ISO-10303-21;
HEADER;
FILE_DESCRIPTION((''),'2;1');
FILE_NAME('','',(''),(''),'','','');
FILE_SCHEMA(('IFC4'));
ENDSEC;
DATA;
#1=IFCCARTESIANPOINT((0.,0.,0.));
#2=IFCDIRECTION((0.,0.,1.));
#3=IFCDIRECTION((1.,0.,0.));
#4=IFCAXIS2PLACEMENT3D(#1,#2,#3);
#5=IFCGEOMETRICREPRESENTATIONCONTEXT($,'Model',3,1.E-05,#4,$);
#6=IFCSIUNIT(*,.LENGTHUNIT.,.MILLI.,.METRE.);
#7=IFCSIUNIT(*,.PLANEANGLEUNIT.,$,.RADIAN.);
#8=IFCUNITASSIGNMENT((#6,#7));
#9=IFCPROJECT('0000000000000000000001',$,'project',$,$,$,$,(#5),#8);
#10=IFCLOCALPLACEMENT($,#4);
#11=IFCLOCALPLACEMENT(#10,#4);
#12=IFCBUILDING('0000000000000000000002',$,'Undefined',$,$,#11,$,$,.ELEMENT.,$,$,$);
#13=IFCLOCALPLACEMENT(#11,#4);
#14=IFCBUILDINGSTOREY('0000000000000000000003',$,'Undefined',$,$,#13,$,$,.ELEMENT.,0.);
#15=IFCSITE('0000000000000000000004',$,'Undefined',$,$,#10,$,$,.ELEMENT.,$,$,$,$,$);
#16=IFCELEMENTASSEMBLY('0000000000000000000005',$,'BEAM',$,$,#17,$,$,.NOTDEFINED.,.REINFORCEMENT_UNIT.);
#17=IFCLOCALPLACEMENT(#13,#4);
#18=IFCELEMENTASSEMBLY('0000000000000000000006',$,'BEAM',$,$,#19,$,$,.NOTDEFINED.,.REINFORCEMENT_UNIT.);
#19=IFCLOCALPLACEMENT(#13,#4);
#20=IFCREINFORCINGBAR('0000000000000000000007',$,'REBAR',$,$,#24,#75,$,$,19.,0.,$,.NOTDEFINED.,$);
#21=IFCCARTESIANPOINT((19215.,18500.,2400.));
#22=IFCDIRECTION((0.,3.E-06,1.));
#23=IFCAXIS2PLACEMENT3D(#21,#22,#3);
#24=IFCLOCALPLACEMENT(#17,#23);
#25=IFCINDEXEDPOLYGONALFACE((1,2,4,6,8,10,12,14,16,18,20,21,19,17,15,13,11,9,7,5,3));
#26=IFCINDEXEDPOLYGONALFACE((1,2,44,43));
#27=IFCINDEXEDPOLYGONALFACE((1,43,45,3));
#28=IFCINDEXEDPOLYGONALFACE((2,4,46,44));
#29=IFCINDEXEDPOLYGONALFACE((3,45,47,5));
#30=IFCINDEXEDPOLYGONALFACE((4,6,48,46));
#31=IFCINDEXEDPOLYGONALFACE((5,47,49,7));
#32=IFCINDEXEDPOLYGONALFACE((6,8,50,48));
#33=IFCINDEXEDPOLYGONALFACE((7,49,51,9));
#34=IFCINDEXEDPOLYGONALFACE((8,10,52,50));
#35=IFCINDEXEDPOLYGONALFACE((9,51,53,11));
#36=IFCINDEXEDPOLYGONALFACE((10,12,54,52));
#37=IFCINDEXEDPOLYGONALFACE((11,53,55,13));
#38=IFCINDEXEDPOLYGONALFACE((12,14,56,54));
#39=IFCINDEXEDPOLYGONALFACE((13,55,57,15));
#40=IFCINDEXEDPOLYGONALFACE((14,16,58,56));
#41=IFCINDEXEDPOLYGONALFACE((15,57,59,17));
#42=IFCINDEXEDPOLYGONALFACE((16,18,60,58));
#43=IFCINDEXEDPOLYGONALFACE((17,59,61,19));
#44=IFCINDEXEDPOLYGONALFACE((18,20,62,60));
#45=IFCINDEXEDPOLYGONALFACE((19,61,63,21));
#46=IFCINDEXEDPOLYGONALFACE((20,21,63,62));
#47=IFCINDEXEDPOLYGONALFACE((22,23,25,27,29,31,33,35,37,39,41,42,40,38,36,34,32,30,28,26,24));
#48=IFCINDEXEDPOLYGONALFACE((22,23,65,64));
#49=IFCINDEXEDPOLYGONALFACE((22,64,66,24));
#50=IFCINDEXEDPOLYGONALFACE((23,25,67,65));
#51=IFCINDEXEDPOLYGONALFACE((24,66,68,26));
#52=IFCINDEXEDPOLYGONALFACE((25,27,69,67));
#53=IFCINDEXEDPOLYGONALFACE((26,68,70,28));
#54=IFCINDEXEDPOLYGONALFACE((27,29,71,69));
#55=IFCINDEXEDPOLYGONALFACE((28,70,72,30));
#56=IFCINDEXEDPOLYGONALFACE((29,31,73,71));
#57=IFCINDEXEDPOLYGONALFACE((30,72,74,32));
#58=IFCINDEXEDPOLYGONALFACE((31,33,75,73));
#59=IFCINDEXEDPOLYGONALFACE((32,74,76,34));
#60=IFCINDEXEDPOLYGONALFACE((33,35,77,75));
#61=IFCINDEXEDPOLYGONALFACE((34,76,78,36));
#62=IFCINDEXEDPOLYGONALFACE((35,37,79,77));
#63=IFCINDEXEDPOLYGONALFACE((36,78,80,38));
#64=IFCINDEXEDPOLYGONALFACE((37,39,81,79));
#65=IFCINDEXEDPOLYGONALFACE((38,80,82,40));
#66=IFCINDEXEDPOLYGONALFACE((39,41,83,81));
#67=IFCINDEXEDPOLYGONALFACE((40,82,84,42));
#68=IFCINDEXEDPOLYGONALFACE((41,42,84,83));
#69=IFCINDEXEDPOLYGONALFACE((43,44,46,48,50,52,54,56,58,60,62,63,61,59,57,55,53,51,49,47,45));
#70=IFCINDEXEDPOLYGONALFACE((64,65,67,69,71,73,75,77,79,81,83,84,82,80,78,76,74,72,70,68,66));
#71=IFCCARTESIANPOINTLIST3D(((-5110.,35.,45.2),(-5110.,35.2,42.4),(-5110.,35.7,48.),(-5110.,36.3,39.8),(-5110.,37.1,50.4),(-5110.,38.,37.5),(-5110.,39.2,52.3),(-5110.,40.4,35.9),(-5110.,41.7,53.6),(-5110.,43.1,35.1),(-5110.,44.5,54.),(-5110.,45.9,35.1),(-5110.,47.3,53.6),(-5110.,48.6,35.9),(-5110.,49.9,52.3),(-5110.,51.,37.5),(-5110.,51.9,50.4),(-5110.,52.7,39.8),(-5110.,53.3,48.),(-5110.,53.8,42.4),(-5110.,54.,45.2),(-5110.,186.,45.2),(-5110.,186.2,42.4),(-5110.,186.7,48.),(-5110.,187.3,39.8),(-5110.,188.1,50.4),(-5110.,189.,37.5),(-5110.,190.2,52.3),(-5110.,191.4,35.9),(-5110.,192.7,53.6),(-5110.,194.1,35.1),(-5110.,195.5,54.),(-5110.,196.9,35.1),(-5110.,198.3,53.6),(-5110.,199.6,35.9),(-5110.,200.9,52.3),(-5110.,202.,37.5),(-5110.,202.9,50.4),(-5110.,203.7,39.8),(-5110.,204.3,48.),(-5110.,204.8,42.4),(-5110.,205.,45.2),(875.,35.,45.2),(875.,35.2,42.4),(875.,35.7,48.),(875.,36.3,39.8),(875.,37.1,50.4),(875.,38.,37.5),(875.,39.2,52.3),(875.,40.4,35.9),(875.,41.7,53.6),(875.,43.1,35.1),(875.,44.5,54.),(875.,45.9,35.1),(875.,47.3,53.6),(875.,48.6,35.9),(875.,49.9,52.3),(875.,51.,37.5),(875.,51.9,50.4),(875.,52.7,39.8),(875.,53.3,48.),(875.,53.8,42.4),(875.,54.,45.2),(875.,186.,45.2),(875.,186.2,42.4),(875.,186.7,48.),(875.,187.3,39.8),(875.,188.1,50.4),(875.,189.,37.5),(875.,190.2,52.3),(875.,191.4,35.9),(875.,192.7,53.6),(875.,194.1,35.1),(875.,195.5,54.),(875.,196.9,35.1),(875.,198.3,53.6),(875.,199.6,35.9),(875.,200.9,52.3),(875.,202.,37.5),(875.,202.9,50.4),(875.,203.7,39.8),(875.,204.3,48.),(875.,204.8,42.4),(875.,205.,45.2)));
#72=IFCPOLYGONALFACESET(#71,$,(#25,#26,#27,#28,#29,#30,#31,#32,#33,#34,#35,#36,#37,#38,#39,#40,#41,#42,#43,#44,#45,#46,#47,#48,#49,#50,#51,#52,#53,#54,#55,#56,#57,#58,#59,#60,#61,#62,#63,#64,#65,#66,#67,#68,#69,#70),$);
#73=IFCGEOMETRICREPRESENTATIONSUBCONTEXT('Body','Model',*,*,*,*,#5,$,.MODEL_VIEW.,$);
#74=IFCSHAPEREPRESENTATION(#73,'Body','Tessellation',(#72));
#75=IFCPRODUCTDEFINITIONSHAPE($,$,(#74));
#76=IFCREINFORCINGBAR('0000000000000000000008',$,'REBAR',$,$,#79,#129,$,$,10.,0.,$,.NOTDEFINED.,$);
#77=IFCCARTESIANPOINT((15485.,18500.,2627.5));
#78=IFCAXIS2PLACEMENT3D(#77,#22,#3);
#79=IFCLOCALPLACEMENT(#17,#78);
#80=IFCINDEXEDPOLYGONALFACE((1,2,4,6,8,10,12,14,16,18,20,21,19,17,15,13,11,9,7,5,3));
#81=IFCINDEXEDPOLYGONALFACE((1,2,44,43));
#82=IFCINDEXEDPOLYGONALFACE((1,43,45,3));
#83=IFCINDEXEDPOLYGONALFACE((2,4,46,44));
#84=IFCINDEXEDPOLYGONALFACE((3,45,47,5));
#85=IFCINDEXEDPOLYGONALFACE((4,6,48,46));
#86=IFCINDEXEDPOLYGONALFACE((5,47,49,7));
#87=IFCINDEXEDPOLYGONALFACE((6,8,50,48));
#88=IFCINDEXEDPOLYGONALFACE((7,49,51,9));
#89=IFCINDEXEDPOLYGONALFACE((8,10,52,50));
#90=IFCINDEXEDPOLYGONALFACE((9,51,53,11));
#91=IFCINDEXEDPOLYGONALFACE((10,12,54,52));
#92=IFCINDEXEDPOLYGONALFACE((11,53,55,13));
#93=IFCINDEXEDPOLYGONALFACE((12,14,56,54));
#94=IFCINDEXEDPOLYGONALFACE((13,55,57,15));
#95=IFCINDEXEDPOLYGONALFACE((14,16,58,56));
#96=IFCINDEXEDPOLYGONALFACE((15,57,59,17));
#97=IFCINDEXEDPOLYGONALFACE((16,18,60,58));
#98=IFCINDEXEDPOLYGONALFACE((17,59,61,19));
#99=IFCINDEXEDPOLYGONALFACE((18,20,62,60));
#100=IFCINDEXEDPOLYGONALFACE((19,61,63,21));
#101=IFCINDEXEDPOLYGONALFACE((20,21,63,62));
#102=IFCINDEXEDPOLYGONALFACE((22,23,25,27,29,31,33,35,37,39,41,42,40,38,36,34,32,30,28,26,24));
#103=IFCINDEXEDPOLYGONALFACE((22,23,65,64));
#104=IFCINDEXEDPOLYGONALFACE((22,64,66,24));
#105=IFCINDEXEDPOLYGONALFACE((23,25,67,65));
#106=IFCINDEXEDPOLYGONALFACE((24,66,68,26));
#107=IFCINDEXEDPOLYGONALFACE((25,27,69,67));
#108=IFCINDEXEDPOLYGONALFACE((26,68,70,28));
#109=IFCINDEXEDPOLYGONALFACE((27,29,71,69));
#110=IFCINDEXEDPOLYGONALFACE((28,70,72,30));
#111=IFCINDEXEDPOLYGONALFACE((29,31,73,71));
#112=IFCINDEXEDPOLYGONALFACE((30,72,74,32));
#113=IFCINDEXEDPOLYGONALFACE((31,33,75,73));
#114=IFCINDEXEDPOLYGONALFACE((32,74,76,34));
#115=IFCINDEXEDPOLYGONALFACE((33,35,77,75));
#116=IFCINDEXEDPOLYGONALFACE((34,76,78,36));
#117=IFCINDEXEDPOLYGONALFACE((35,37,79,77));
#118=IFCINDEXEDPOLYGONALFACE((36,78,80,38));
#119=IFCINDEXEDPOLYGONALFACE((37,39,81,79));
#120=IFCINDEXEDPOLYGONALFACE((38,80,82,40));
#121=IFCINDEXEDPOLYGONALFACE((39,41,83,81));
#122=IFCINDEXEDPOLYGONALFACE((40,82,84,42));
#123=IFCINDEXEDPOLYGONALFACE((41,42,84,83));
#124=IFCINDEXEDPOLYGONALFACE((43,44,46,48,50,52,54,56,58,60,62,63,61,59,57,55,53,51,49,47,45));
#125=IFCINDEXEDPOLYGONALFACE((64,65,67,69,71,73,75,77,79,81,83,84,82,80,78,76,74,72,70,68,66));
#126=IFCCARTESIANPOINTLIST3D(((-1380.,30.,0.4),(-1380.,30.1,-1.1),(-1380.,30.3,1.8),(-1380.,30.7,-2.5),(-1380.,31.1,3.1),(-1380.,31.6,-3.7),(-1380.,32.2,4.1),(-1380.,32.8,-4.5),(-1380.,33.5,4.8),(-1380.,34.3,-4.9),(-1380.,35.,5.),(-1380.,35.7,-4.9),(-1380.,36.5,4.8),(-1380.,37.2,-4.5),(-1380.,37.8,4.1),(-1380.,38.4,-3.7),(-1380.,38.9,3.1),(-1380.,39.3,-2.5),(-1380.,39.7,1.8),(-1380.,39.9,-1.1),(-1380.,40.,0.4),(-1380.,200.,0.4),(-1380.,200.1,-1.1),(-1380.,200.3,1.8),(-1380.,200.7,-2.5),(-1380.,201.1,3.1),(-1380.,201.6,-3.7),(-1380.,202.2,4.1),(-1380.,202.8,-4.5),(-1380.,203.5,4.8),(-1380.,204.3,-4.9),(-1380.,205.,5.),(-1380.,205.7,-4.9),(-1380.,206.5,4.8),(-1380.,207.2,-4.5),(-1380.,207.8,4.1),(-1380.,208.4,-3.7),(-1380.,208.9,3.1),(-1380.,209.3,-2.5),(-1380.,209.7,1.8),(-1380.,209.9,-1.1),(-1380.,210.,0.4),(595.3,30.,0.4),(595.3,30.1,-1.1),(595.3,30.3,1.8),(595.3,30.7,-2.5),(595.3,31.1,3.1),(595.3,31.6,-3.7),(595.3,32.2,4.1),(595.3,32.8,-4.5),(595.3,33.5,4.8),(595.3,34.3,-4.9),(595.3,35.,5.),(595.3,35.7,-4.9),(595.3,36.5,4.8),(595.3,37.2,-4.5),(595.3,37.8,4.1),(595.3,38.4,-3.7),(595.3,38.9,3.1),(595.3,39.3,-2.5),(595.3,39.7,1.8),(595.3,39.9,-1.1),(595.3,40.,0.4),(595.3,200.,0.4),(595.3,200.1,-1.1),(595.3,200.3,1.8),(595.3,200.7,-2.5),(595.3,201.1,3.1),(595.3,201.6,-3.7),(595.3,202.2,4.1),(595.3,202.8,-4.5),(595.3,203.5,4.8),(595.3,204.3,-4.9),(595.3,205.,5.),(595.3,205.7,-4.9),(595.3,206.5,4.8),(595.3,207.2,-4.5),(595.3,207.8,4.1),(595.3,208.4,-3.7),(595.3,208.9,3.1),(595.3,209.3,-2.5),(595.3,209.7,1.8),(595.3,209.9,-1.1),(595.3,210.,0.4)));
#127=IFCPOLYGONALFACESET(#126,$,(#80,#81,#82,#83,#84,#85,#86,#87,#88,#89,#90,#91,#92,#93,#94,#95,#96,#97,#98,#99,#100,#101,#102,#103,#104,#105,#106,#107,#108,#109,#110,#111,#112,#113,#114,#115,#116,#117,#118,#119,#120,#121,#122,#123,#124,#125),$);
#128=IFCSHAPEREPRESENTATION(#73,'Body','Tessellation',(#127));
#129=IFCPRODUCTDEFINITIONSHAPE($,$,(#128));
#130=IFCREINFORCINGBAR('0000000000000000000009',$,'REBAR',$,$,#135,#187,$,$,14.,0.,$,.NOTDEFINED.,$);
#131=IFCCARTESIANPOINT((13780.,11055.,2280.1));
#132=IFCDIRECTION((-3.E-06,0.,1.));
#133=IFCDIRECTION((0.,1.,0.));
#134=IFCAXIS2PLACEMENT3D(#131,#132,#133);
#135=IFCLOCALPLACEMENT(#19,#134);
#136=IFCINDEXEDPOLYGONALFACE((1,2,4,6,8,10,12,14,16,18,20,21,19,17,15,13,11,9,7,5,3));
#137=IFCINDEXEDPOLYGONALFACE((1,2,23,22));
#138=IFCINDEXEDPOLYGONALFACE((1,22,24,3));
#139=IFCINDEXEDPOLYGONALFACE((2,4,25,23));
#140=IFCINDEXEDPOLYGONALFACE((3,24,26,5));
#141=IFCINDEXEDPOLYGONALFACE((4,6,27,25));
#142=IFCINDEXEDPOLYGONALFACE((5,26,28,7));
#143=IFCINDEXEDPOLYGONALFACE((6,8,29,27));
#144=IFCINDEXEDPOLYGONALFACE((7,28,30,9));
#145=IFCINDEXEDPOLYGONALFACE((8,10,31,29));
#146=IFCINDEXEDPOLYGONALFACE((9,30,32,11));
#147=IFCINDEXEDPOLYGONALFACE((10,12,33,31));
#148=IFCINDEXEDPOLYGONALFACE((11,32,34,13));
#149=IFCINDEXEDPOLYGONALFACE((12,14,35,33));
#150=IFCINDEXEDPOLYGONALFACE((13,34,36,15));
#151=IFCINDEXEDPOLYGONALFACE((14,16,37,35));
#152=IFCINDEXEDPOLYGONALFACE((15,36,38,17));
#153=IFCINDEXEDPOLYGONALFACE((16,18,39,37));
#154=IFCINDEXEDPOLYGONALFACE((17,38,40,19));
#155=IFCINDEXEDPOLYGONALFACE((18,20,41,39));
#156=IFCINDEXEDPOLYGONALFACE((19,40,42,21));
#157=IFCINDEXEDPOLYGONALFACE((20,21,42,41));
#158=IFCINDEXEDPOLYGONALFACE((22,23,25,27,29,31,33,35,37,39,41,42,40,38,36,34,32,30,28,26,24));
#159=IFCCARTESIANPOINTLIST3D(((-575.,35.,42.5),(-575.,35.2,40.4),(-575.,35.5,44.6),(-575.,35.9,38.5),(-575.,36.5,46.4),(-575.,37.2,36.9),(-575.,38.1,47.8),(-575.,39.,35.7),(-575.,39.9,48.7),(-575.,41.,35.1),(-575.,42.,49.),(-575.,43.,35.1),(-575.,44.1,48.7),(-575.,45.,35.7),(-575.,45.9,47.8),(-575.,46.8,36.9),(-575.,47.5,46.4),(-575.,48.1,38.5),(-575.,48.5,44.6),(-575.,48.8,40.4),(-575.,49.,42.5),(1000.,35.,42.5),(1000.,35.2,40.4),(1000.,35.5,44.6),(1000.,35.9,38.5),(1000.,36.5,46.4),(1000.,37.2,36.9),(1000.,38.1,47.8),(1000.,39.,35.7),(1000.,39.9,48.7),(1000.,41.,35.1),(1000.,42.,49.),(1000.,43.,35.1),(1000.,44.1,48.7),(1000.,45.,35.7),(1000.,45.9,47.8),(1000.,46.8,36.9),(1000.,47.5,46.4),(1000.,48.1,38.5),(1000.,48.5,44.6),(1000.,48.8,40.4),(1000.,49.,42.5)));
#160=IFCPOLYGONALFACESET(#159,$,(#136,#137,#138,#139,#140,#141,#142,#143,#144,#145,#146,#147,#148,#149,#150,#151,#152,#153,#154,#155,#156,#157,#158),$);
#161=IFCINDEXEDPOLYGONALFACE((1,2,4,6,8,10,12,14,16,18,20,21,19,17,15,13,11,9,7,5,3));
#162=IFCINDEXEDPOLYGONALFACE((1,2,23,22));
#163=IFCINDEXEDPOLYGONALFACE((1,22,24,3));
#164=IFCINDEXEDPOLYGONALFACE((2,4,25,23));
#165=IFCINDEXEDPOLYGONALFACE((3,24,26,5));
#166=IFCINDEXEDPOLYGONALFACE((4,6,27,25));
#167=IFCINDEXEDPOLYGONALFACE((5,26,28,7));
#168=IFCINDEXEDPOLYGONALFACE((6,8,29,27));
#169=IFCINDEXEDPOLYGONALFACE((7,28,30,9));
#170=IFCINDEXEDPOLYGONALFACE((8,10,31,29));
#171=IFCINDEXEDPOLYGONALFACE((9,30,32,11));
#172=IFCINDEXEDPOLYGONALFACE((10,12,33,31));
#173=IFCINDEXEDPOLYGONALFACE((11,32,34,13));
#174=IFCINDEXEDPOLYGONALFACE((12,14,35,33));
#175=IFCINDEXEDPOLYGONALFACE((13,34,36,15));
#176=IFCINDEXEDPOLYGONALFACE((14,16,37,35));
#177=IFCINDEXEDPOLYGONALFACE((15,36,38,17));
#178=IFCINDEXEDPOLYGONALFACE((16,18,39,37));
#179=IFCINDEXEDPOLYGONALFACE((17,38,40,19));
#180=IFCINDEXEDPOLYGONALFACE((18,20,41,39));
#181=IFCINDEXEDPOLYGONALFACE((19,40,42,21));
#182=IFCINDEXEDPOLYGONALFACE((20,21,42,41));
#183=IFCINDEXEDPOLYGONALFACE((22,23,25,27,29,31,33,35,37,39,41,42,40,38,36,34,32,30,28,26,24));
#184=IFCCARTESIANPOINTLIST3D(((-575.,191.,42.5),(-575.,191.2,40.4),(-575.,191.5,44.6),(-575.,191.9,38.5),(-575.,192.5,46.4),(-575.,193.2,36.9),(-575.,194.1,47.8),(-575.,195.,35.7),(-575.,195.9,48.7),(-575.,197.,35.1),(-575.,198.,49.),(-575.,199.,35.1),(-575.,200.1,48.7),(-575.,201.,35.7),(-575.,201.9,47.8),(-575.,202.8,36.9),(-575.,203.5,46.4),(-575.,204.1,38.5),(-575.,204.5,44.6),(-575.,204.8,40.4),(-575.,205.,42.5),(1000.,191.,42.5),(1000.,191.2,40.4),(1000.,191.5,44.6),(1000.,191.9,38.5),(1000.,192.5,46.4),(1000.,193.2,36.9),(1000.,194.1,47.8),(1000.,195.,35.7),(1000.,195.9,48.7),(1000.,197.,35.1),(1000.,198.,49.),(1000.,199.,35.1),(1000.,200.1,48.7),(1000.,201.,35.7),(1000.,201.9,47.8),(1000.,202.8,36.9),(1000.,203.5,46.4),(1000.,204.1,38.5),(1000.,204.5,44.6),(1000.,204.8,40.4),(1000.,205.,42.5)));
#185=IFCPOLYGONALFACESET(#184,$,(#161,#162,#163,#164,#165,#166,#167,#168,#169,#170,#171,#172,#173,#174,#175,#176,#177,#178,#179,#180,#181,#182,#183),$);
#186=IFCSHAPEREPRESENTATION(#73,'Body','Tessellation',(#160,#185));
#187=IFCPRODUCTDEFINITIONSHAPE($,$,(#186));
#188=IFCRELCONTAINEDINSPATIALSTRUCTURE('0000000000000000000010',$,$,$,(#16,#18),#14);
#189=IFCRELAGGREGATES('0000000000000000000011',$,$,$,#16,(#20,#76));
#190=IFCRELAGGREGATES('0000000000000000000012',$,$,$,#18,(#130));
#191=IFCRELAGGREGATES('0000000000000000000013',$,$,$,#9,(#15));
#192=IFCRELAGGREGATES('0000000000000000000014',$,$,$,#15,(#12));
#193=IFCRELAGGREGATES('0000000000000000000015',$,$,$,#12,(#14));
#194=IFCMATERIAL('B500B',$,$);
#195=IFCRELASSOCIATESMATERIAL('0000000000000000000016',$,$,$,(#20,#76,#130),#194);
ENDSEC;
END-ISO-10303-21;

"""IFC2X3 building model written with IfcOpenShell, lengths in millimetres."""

from ifc_helpers import new_model, entity, si_unit, frame, origin_with_axes, place, context, subcontext, project, spatial, source, transform, mapped, material, element, aggregate, save


model = new_model("IFC2X3")

# Units and contexts
model_context = context("Model", 3, precision=1e-05, world=origin_with_axes())
body_context = subcontext(model_context, "Body", "Model", "MODEL_VIEW")
ifc_project = project(units=[si_unit("LENGTHUNIT", "METRE", prefix="MILLI"), si_unit("PLANEANGLEUNIT", "RADIAN")], contexts=[model_context])

# Site, building, storey
site_placement = place(None, origin_with_axes())
site = spatial("IfcSite", under=ifc_project, at=site_placement, Name="Undefined", CompositionType="ELEMENT")
building_placement = place(site_placement, origin_with_axes())
building = spatial("IfcBuilding", under=site, at=building_placement, Name="Undefined", CompositionType="ELEMENT")
storey_placement = place(building_placement, origin_with_axes())
storey = spatial("IfcBuildingStorey", under=building, at=storey_placement, Name="Undefined", CompositionType="ELEMENT", Elevation=0.0)

# Element assembly
assembly_1_placement = place(storey_placement, origin_with_axes())
assembly_1 = element("IfcElementAssembly", 1, at=assembly_1_placement, inside=storey, Name="BEAM", AssemblyPlace="NOTDEFINED", PredefinedType="REINFORCEMENT_UNIT")

# Element assembly
assembly_2_placement = place(storey_placement, origin_with_axes())
assembly_2 = element("IfcElementAssembly", 2, at=assembly_2_placement, inside=storey, Name="BEAM", AssemblyPlace="NOTDEFINED", PredefinedType="REINFORCEMENT_UNIT")

# Reinforcing bars
ifc_material_1 = material(Name="B500B")
shared_shape_1 = source(origin_with_axes(), body_context, "Body", "AdvancedSweptSolid", [
    entity("IfcSweptDiskSolid", entity("IfcTrimmedCurve", entity("IfcLine", entity("IfcCartesianPoint", [0.0, 0.0, 0.0]), entity("IfcVector", entity("IfcDirection", [1.0, 0.0, 0.0]), 1.0)), [entity("IfcParameterValue", 0.0)], [entity("IfcParameterValue", 5984.999614)], True, "PARAMETER"), 9.5, None, 0.0, 5985.0),
])
shared_shape_2 = source(origin_with_axes(), body_context, "Body", "AdvancedSweptSolid", [
    entity("IfcSweptDiskSolid", entity("IfcTrimmedCurve", entity("IfcLine", entity("IfcCartesianPoint", [0.0, 0.0, 0.0]), entity("IfcVector", entity("IfcDirection", [1.0, 0.0, 0.0]), 1.0)), [entity("IfcParameterValue", 0.0)], [entity("IfcParameterValue", 5984.999614)], True, "PARAMETER"), 9.5, None, 0.0, 5985.0),
])
reinforcing_bar_1_placement = place(assembly_1_placement, frame((19215.0, 18500.0, 2400.0), z_axis=(0.0, 0.000003, 1.0), x_axis=(1.0, 0.0, 0.0)))
reinforcing_bar_1 = element("IfcReinforcingBar", 3, at=reinforcing_bar_1_placement, material=ifc_material_1, Name="REBAR", BarRole="NOTDEFINED", CrossSectionArea=0.0, NominalDiameter=19.0, context=body_context, shape_type="MappedRepresentation", body=[
    mapped(shared_shape_1, transform((-5110.0, 44.5, 44.5))),
    mapped(shared_shape_2, transform((-5110.0, 195.5, 44.5))),
])
shared_shape_3 = source(origin_with_axes(), body_context, "Body", "AdvancedSweptSolid", [
    entity("IfcSweptDiskSolid", entity("IfcTrimmedCurve", entity("IfcLine", entity("IfcCartesianPoint", [0.0, 0.0, 0.0]), entity("IfcVector", entity("IfcDirection", [1.0, 0.0, 0.0]), 1.0)), [entity("IfcParameterValue", 0.0)], [entity("IfcParameterValue", 1975.269614)], True, "PARAMETER"), 5.0, None, 0.0, 1975.3),
])
shared_shape_4 = source(origin_with_axes(), body_context, "Body", "AdvancedSweptSolid", [
    entity("IfcSweptDiskSolid", entity("IfcTrimmedCurve", entity("IfcLine", entity("IfcCartesianPoint", [0.0, 0.0, 0.0]), entity("IfcVector", entity("IfcDirection", [1.0, 0.0, 0.0]), 1.0)), [entity("IfcParameterValue", 0.0)], [entity("IfcParameterValue", 1975.269614)], True, "PARAMETER"), 5.0, None, 0.0, 1975.3),
])
reinforcing_bar_2_placement = place(assembly_1_placement, frame((15485.0, 18500.0, 2627.5), z_axis=(0.0, 0.000003, 1.0), x_axis=(1.0, 0.0, 0.0)))
reinforcing_bar_2 = element("IfcReinforcingBar", 4, at=reinforcing_bar_2_placement, material=ifc_material_1, Name="REBAR", BarRole="NOTDEFINED", CrossSectionArea=0.0, NominalDiameter=10.0, context=body_context, shape_type="MappedRepresentation", body=[
    mapped(shared_shape_3, transform((-1380.0, 35.0, 0.0))),
    mapped(shared_shape_4, transform((-1380.0, 205.0, 0.0))),
])
aggregate(assembly_1, [reinforcing_bar_1, reinforcing_bar_2])
shared_shape_5 = source(origin_with_axes(), body_context, "Body", "AdvancedSweptSolid", [
    entity("IfcSweptDiskSolid", entity("IfcTrimmedCurve", entity("IfcLine", entity("IfcCartesianPoint", [0.0, 0.0, 0.0]), entity("IfcVector", entity("IfcDirection", [1.0, 0.0, 0.0]), 1.0)), [entity("IfcParameterValue", 0.0)], [entity("IfcParameterValue", 1574.999613)], True, "PARAMETER"), 7.0, None, 0.0, 1575.0),
])
shared_shape_6 = source(origin_with_axes(), body_context, "Body", "AdvancedSweptSolid", [
    entity("IfcSweptDiskSolid", entity("IfcTrimmedCurve", entity("IfcLine", entity("IfcCartesianPoint", [0.0, 0.0, 0.0]), entity("IfcVector", entity("IfcDirection", [1.0, 0.0, 0.0]), 1.0)), [entity("IfcParameterValue", 0.0)], [entity("IfcParameterValue", 1574.999613)], True, "PARAMETER"), 7.0, None, 0.0, 1575.0),
])
reinforcing_bar_3_placement = place(assembly_2_placement, frame((13780.0, 11055.0, 2280.1), z_axis=(-0.000003, 0.0, 1.0), x_axis=(0.0, 1.0, 0.0)))
reinforcing_bar_3 = element("IfcReinforcingBar", 5, at=reinforcing_bar_3_placement, material=ifc_material_1, Name="REBAR", BarRole="NOTDEFINED", CrossSectionArea=0.0, NominalDiameter=14.0, context=body_context, shape_type="MappedRepresentation", body=[
    mapped(shared_shape_5, transform((-575.0, 42.0, 42.0))),
    mapped(shared_shape_6, transform((-575.0, 198.0, 42.0))),
])
aggregate(assembly_2, [reinforcing_bar_3])

save(model, "model.ifc")
